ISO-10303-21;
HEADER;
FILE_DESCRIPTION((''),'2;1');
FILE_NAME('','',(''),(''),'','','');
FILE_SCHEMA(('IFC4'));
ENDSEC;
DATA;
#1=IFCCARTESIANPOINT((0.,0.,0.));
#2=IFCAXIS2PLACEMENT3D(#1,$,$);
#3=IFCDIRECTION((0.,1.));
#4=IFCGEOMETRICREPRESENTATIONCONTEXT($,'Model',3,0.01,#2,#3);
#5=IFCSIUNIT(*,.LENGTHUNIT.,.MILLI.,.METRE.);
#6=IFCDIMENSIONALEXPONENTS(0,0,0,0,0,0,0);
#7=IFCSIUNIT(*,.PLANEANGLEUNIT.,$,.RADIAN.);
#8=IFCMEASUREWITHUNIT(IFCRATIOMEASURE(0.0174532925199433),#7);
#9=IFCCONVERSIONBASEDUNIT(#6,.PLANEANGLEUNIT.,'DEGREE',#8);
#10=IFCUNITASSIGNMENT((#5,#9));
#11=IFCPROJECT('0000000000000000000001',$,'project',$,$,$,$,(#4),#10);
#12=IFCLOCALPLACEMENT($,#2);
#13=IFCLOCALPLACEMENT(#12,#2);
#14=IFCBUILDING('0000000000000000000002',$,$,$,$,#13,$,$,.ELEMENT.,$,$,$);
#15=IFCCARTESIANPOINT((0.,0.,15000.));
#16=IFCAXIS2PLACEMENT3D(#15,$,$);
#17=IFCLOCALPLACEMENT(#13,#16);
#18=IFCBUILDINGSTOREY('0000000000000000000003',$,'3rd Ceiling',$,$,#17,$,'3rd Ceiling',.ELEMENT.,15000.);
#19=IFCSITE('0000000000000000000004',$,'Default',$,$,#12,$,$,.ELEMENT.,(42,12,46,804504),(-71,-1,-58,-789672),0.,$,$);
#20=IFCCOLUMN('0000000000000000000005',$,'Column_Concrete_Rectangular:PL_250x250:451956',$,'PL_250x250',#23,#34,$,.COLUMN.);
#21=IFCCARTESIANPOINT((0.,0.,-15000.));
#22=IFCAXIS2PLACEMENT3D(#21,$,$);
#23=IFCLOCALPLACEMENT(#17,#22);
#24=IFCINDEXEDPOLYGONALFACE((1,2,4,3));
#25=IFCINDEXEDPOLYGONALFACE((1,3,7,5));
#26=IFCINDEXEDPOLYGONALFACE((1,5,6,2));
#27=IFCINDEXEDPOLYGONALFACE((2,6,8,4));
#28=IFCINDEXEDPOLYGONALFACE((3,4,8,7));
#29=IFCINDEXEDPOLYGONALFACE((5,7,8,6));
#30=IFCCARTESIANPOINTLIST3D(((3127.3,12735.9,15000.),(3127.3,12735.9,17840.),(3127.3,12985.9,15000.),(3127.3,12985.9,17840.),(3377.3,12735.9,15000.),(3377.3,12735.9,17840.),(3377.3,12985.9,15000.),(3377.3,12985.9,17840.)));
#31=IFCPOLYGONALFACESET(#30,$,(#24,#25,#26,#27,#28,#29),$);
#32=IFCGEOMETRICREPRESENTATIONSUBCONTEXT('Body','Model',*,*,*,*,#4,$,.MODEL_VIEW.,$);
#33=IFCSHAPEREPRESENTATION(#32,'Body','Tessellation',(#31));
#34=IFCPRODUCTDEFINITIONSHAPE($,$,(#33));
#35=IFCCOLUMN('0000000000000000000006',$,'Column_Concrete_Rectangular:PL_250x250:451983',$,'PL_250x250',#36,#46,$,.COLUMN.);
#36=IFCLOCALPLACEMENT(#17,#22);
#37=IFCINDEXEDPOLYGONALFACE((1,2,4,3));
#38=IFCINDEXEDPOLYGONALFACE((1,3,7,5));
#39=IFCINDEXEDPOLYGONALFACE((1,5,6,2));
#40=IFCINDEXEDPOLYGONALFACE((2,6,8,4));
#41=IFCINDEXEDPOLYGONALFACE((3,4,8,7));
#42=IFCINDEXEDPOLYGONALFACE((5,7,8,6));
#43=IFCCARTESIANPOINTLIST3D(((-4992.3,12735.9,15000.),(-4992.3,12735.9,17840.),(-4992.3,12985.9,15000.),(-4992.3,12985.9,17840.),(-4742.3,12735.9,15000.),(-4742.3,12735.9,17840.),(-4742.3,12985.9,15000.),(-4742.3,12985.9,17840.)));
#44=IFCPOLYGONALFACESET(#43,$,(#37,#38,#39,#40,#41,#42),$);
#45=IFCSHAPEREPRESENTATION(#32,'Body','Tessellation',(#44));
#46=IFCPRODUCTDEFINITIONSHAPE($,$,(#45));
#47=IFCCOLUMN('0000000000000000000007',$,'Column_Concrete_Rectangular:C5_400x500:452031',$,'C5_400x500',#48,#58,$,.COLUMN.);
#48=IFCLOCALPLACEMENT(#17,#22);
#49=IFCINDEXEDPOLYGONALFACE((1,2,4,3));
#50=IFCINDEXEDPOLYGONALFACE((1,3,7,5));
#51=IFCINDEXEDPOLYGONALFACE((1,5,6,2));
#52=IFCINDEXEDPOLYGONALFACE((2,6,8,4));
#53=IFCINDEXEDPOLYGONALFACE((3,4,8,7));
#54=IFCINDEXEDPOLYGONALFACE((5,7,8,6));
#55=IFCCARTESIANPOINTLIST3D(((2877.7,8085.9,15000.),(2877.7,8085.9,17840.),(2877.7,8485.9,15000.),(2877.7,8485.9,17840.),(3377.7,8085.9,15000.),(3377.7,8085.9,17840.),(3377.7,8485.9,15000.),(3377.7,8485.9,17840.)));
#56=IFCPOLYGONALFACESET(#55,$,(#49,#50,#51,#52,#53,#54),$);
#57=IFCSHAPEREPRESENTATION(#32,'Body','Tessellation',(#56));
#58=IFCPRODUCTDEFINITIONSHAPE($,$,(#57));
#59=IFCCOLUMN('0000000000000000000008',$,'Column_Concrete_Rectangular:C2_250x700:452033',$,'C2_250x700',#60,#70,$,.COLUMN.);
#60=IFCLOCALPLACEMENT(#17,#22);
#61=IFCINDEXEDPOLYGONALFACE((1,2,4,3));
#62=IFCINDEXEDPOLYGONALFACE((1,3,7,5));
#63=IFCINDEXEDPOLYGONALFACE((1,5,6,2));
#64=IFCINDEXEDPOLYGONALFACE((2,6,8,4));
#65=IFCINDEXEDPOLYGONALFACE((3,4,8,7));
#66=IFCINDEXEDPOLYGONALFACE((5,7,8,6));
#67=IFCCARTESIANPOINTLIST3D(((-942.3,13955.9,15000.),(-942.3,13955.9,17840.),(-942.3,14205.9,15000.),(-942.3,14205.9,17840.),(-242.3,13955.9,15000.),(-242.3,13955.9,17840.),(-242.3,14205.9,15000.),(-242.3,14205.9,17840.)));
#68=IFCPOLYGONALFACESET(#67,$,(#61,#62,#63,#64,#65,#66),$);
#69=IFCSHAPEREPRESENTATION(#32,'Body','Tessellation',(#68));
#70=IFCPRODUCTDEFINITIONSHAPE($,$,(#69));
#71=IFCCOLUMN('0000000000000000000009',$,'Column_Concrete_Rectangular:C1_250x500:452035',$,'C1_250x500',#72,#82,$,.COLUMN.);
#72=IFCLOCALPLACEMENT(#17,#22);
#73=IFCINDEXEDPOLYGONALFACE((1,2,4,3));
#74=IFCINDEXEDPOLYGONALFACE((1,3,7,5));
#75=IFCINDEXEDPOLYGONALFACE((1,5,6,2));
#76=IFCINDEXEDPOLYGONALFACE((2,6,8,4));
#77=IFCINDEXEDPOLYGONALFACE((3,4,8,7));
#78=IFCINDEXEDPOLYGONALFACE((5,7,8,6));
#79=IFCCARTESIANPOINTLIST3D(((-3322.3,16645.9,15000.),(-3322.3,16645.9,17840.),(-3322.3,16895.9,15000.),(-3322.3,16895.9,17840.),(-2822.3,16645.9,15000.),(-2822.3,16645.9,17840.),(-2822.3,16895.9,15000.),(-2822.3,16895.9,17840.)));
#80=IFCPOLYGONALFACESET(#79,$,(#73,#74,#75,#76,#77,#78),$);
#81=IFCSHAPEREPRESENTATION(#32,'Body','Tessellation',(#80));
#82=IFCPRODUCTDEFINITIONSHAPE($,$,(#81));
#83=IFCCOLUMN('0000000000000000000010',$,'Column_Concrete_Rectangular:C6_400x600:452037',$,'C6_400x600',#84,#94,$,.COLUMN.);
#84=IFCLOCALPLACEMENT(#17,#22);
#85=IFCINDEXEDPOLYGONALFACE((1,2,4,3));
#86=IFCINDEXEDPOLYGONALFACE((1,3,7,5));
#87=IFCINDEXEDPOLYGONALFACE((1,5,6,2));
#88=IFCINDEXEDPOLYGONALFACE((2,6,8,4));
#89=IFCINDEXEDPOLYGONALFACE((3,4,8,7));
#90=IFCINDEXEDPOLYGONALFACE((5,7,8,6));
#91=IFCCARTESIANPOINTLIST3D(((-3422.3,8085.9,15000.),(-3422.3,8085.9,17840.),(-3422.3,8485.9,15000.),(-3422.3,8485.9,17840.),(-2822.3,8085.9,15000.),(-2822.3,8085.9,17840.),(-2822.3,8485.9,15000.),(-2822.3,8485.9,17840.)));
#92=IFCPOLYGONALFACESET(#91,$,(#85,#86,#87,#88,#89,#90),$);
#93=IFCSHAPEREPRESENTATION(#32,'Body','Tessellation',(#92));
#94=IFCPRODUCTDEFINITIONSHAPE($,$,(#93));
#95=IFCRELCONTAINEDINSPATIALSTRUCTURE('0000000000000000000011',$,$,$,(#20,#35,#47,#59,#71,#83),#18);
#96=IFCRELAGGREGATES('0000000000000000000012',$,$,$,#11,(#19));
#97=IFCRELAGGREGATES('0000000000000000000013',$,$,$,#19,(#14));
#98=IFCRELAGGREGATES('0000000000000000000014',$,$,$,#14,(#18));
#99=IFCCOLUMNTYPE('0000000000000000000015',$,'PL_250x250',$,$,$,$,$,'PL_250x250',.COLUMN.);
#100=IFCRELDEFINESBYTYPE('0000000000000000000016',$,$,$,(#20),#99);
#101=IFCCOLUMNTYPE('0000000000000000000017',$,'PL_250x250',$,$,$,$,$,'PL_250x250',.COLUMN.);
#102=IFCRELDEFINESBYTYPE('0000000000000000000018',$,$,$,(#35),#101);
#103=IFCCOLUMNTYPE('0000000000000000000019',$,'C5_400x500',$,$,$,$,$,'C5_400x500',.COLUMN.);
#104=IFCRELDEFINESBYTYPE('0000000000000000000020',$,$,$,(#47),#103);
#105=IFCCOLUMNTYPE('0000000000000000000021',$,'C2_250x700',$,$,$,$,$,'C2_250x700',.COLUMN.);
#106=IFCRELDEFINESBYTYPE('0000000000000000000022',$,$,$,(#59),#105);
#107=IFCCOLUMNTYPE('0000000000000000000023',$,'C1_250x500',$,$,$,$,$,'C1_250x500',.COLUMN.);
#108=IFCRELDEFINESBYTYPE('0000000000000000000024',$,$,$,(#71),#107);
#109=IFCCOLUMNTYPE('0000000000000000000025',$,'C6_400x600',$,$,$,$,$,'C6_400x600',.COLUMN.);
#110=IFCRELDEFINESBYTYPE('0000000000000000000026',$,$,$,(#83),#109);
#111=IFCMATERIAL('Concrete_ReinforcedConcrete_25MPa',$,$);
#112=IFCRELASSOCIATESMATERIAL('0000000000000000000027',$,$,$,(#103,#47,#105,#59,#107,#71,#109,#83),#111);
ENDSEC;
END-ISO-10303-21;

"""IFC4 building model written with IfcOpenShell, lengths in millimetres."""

from ifc_helpers import new_model, entity, si_unit, converted_unit, direction, frame, frame_2d, origin, origin_2d_with_axis, place, context, subcontext, project, spatial, rectangle, extrude, source, transform, mapped, material, type_object, type_shapes, element, save


model = new_model("IFC4")

# Units and contexts
model_context = context("Model", 3, precision=0.01, world=origin(), true_north=direction((0.0, 1.0)))
body_context = subcontext(model_context, "Body", "Model", "MODEL_VIEW")
ifc_project = project(units=[si_unit("LENGTHUNIT", "METRE", prefix="MILLI"), converted_unit("PLANEANGLEUNIT", "DEGREE", entity("IfcRatioMeasure", 0.0174532925199433), si_unit("PLANEANGLEUNIT", "RADIAN"), dimensions=[0, 0, 0, 0, 0, 0, 0])], contexts=[model_context])

# Site, building, storey
site_placement = place(None, origin())
site = spatial("IfcSite", under=ifc_project, at=site_placement, Name="Default", CompositionType="ELEMENT", RefLatitude=(42, 12, 46, 804504), RefLongitude=(-71, -1, -58, -789672), RefElevation=0.0)
building_placement = place(site_placement, origin())
building = spatial("IfcBuilding", under=site, at=building_placement, CompositionType="ELEMENT")
storey_placement = place(building_placement, frame((0.0, 0.0, 15000.0)))
storey = spatial("IfcBuildingStorey", under=building, at=storey_placement, Name="3rd Ceiling", LongName="3rd Ceiling", CompositionType="ELEMENT", Elevation=15000.0)

# Columns
column_type_1 = type_object("IfcColumnType", Name="PL_250x250", ElementType="PL_250x250", PredefinedType="COLUMN")
shared_shape_1 = source(origin(), body_context, "Body", "SweptSolid", [
    extrude(rectangle(XDim=250.0, YDim=250.0, at=frame_2d((0.0, 0.0), x_axis=(1.0, 0.0))), frame((3252.3, 12860.9, 15000.0), z_axis=(0.0, 0.0, 1.0), x_axis=(0.0, -1.0, 0.0)), (0.0, 0.0, 1.0), 2840.0),
])
type_shapes(column_type_1, [shared_shape_1])
column_1_placement = place(storey_placement, frame((0.0, 0.0, -15000.0)))
element("IfcColumn", 1, at=column_1_placement, inside=storey, type_object=column_type_1, Name="Column_Concrete_Rectangular:PL_250x250:451956", ObjectType="PL_250x250", PredefinedType="COLUMN", context=body_context, shape_type="MappedRepresentation", body=[
    mapped(shared_shape_1, transform((0.0, 0.0, 0.0), scale=1.0)),
])
column_type_2 = type_object("IfcColumnType", Name="PL_250x250", ElementType="PL_250x250", PredefinedType="COLUMN")
shared_shape_2 = source(origin(), body_context, "Body", "SweptSolid", [
    extrude(rectangle(XDim=250.0, YDim=250.0, at=frame_2d((0.0, 0.0), x_axis=(1.0, 0.0))), frame((-4867.3, 12860.9, 15000.0), z_axis=(0.0, 0.0, 1.0), x_axis=(0.0, -1.0, 0.0)), (0.0, 0.0, 1.0), 2840.0),
])
type_shapes(column_type_2, [shared_shape_2])
column_2_placement = place(storey_placement, frame((0.0, 0.0, -15000.0)))
element("IfcColumn", 2, at=column_2_placement, inside=storey, type_object=column_type_2, Name="Column_Concrete_Rectangular:PL_250x250:451983", ObjectType="PL_250x250", PredefinedType="COLUMN", context=body_context, shape_type="MappedRepresentation", body=[
    mapped(shared_shape_2, transform((0.0, 0.0, 0.0), scale=1.0)),
])
ifc_material = material(Name="Concrete_ReinforcedConcrete_25MPa")
column_type_3 = type_object("IfcColumnType", Name="C5_400x500", ElementType="C5_400x500", PredefinedType="COLUMN", material=ifc_material)
shared_shape_3 = source(origin(), body_context, "Body", "SweptSolid", [
    extrude(rectangle(XDim=400.0, YDim=500.0, at=origin_2d_with_axis()), frame((3127.7, 8285.9, 15000.0), z_axis=(0.0, 0.0, 1.0), x_axis=(0.0, -1.0, 0.0)), (0.0, 0.0, 1.0), 2840.0),
])
type_shapes(column_type_3, [shared_shape_3])
column_3_placement = place(storey_placement, frame((0.0, 0.0, -15000.0)))
element("IfcColumn", 3, at=column_3_placement, inside=storey, type_object=column_type_3, material=ifc_material, Name="Column_Concrete_Rectangular:C5_400x500:452031", ObjectType="C5_400x500", PredefinedType="COLUMN", context=body_context, shape_type="MappedRepresentation", body=[
    mapped(shared_shape_3, transform((0.0, 0.0, 0.0), scale=1.0)),
])
column_type_4 = type_object("IfcColumnType", Name="C2_250x700", ElementType="C2_250x700", PredefinedType="COLUMN", material=ifc_material)
shared_shape_4 = source(origin(), body_context, "Body", "SweptSolid", [
    extrude(rectangle(XDim=250.0, YDim=700.0, at=origin_2d_with_axis()), frame((-592.3, 14080.9, 15000.0), z_axis=(0.0, 0.0, 1.0), x_axis=(0.0, -1.0, 0.0)), (0.0, 0.0, 1.0), 2840.0),
])
type_shapes(column_type_4, [shared_shape_4])
column_4_placement = place(storey_placement, frame((0.0, 0.0, -15000.0)))
element("IfcColumn", 4, at=column_4_placement, inside=storey, type_object=column_type_4, material=ifc_material, Name="Column_Concrete_Rectangular:C2_250x700:452033", ObjectType="C2_250x700", PredefinedType="COLUMN", context=body_context, shape_type="MappedRepresentation", body=[
    mapped(shared_shape_4, transform((0.0, 0.0, 0.0), scale=1.0)),
])
column_type_5 = type_object("IfcColumnType", Name="C1_250x500", ElementType="C1_250x500", PredefinedType="COLUMN", material=ifc_material)
shared_shape_5 = source(origin(), body_context, "Body", "SweptSolid", [
    extrude(rectangle(XDim=250.0, YDim=500.0, at=frame_2d((0.0, 0.0), x_axis=(1.0, 0.0))), frame((-3072.3, 16770.9, 15000.0), z_axis=(0.0, 0.0, 1.0), x_axis=(0.0, -1.0, 0.0)), (0.0, 0.0, 1.0), 2840.0),
])
type_shapes(column_type_5, [shared_shape_5])
column_5_placement = place(storey_placement, frame((0.0, 0.0, -15000.0)))
element("IfcColumn", 5, at=column_5_placement, inside=storey, type_object=column_type_5, material=ifc_material, Name="Column_Concrete_Rectangular:C1_250x500:452035", ObjectType="C1_250x500", PredefinedType="COLUMN", context=body_context, shape_type="MappedRepresentation", body=[
    mapped(shared_shape_5, transform((0.0, 0.0, 0.0), scale=1.0)),
])
column_type_6 = type_object("IfcColumnType", Name="C6_400x600", ElementType="C6_400x600", PredefinedType="COLUMN", material=ifc_material)
shared_shape_6 = source(origin(), body_context, "Body", "SweptSolid", [
    extrude(rectangle(XDim=400.0, YDim=600.0, at=origin_2d_with_axis()), frame((-3122.3, 8285.9, 15000.0), z_axis=(0.0, 0.0, 1.0), x_axis=(0.0, -1.0, 0.0)), (0.0, 0.0, 1.0), 2840.0),
])
type_shapes(column_type_6, [shared_shape_6])
column_6_placement = place(storey_placement, frame((0.0, 0.0, -15000.0)))
element("IfcColumn", 6, at=column_6_placement, inside=storey, type_object=column_type_6, material=ifc_material, Name="Column_Concrete_Rectangular:C6_400x600:452037", ObjectType="C6_400x600", PredefinedType="COLUMN", context=body_context, shape_type="MappedRepresentation", body=[
    mapped(shared_shape_6, transform((0.0, 0.0, 0.0), scale=1.0)),
])

save(model, "model.ifc")
